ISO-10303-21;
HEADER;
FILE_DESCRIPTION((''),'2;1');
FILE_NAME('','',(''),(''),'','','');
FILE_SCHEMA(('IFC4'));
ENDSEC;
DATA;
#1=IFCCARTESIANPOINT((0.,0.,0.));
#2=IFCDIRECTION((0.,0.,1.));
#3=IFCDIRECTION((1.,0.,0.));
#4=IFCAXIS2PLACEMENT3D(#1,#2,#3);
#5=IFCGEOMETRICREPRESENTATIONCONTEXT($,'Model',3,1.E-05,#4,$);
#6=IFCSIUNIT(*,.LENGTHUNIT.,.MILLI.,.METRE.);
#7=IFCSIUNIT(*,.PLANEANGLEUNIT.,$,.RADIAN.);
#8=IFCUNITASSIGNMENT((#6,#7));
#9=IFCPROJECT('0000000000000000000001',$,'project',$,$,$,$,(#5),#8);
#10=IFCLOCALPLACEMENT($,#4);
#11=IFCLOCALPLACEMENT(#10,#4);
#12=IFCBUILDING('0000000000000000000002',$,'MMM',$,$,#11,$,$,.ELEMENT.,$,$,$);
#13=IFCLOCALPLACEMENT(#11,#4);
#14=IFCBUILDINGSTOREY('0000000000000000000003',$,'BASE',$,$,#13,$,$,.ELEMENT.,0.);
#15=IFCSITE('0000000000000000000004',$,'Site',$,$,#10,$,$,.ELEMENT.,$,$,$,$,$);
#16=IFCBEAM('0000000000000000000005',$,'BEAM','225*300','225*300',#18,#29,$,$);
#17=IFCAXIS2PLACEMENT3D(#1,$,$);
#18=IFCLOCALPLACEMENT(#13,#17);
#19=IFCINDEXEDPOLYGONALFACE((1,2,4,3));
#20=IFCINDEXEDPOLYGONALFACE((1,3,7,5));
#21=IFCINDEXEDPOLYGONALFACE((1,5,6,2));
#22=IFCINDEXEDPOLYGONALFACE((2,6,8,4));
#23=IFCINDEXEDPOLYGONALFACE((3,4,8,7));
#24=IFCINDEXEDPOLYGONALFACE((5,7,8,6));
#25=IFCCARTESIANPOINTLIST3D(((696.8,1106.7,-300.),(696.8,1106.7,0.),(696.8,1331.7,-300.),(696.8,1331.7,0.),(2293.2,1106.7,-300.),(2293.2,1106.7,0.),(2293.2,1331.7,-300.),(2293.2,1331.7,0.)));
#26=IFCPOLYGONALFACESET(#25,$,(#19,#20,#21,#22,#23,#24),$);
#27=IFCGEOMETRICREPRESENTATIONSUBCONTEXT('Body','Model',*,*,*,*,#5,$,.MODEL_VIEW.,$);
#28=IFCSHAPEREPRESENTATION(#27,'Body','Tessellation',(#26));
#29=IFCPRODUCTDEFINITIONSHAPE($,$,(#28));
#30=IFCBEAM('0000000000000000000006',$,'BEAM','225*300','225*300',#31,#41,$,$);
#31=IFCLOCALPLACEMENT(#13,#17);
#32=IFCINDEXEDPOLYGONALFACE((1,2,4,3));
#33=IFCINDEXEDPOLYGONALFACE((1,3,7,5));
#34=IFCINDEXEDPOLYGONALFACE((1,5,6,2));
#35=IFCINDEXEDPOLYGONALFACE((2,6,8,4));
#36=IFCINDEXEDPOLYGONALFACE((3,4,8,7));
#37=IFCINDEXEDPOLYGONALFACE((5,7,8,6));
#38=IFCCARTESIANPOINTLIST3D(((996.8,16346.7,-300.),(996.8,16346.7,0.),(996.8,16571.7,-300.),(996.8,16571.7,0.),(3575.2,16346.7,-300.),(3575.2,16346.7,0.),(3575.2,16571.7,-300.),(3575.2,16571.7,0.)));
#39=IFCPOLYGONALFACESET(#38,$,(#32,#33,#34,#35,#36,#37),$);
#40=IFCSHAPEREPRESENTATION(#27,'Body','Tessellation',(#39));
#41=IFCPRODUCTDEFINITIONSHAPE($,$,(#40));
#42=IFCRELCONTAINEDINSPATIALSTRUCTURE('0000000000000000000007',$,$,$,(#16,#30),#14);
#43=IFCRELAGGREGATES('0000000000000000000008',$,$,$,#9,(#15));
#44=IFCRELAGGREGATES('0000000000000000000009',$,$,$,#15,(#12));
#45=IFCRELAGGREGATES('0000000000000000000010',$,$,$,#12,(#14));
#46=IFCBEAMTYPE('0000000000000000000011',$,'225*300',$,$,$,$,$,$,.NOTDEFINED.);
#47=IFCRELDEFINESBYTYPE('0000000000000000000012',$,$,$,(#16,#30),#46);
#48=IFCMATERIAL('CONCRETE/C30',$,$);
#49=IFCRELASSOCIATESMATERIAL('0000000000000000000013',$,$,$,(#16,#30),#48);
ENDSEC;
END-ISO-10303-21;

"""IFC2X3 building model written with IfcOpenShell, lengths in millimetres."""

from ifc_helpers import new_model, si_unit, frame, origin_with_axes, origin_2d_with_axis, place, context, subcontext, project, spatial, rectangle, extrude, material, type_object, element, save


model = new_model("IFC2X3")

# Units and contexts
model_context = context("Model", 3, precision=1e-05, world=origin_with_axes())
body_context = subcontext(model_context, "Body", "Model", "MODEL_VIEW")
ifc_project = project(units=[si_unit("LENGTHUNIT", "METRE", prefix="MILLI"), si_unit("PLANEANGLEUNIT", "RADIAN")], contexts=[model_context])

# Site, building, storey
site_placement = place(None, origin_with_axes())
site = spatial("IfcSite", under=ifc_project, at=site_placement, Name="Site", CompositionType="ELEMENT")
building_placement = place(site_placement, origin_with_axes())
building = spatial("IfcBuilding", under=site, at=building_placement, Name="MMM", CompositionType="ELEMENT")
storey_placement = place(building_placement, origin_with_axes())
storey = spatial("IfcBuildingStorey", under=building, at=storey_placement, Name="BASE", CompositionType="ELEMENT", Elevation=0.0)

# Shared definitions
ifc_material = material(Name="CONCRETE/C30")

# Beams
beam_type = type_object("IfcBeamType", Name="225*300", PredefinedType="NOTDEFINED")
beam_1_placement = place(storey_placement, frame((696.8, 1219.2, -150.0), z_axis=(0.0, 0.0, 1.0), x_axis=(1.0, 0.0, 0.0)))
element("IfcBeam", 1, at=beam_1_placement, inside=storey, type_object=beam_type, material=ifc_material, Name="BEAM", Description="225*300", ObjectType="225*300", context=body_context, shape_type="SweptSolid", body=[
    extrude(rectangle(XDim=225.0, YDim=300.0, at=origin_2d_with_axis()), frame((1596.4, 0.0, 0.0), z_axis=(-1.0, 0.0, 0.0), x_axis=(0.0, -1.0, 0.0)), (0.0, 0.0, 1.0), 1596.4),
])
beam_2_placement = place(storey_placement, frame((996.8, 16459.2, -150.0), z_axis=(0.0, 0.0, 1.0), x_axis=(1.0, 0.0, 0.0)))
element("IfcBeam", 2, at=beam_2_placement, inside=storey, type_object=beam_type, material=ifc_material, Name="BEAM", Description="225*300", ObjectType="225*300", context=body_context, shape_type="SweptSolid", body=[
    extrude(rectangle(XDim=225.0, YDim=300.0, at=origin_2d_with_axis()), frame((2578.4, 0.0, 0.0), z_axis=(-1.0, 0.0, 0.0), x_axis=(0.0, -1.0, 0.0)), (0.0, 0.0, 1.0), 2578.4),
])

save(model, "model.ifc")
